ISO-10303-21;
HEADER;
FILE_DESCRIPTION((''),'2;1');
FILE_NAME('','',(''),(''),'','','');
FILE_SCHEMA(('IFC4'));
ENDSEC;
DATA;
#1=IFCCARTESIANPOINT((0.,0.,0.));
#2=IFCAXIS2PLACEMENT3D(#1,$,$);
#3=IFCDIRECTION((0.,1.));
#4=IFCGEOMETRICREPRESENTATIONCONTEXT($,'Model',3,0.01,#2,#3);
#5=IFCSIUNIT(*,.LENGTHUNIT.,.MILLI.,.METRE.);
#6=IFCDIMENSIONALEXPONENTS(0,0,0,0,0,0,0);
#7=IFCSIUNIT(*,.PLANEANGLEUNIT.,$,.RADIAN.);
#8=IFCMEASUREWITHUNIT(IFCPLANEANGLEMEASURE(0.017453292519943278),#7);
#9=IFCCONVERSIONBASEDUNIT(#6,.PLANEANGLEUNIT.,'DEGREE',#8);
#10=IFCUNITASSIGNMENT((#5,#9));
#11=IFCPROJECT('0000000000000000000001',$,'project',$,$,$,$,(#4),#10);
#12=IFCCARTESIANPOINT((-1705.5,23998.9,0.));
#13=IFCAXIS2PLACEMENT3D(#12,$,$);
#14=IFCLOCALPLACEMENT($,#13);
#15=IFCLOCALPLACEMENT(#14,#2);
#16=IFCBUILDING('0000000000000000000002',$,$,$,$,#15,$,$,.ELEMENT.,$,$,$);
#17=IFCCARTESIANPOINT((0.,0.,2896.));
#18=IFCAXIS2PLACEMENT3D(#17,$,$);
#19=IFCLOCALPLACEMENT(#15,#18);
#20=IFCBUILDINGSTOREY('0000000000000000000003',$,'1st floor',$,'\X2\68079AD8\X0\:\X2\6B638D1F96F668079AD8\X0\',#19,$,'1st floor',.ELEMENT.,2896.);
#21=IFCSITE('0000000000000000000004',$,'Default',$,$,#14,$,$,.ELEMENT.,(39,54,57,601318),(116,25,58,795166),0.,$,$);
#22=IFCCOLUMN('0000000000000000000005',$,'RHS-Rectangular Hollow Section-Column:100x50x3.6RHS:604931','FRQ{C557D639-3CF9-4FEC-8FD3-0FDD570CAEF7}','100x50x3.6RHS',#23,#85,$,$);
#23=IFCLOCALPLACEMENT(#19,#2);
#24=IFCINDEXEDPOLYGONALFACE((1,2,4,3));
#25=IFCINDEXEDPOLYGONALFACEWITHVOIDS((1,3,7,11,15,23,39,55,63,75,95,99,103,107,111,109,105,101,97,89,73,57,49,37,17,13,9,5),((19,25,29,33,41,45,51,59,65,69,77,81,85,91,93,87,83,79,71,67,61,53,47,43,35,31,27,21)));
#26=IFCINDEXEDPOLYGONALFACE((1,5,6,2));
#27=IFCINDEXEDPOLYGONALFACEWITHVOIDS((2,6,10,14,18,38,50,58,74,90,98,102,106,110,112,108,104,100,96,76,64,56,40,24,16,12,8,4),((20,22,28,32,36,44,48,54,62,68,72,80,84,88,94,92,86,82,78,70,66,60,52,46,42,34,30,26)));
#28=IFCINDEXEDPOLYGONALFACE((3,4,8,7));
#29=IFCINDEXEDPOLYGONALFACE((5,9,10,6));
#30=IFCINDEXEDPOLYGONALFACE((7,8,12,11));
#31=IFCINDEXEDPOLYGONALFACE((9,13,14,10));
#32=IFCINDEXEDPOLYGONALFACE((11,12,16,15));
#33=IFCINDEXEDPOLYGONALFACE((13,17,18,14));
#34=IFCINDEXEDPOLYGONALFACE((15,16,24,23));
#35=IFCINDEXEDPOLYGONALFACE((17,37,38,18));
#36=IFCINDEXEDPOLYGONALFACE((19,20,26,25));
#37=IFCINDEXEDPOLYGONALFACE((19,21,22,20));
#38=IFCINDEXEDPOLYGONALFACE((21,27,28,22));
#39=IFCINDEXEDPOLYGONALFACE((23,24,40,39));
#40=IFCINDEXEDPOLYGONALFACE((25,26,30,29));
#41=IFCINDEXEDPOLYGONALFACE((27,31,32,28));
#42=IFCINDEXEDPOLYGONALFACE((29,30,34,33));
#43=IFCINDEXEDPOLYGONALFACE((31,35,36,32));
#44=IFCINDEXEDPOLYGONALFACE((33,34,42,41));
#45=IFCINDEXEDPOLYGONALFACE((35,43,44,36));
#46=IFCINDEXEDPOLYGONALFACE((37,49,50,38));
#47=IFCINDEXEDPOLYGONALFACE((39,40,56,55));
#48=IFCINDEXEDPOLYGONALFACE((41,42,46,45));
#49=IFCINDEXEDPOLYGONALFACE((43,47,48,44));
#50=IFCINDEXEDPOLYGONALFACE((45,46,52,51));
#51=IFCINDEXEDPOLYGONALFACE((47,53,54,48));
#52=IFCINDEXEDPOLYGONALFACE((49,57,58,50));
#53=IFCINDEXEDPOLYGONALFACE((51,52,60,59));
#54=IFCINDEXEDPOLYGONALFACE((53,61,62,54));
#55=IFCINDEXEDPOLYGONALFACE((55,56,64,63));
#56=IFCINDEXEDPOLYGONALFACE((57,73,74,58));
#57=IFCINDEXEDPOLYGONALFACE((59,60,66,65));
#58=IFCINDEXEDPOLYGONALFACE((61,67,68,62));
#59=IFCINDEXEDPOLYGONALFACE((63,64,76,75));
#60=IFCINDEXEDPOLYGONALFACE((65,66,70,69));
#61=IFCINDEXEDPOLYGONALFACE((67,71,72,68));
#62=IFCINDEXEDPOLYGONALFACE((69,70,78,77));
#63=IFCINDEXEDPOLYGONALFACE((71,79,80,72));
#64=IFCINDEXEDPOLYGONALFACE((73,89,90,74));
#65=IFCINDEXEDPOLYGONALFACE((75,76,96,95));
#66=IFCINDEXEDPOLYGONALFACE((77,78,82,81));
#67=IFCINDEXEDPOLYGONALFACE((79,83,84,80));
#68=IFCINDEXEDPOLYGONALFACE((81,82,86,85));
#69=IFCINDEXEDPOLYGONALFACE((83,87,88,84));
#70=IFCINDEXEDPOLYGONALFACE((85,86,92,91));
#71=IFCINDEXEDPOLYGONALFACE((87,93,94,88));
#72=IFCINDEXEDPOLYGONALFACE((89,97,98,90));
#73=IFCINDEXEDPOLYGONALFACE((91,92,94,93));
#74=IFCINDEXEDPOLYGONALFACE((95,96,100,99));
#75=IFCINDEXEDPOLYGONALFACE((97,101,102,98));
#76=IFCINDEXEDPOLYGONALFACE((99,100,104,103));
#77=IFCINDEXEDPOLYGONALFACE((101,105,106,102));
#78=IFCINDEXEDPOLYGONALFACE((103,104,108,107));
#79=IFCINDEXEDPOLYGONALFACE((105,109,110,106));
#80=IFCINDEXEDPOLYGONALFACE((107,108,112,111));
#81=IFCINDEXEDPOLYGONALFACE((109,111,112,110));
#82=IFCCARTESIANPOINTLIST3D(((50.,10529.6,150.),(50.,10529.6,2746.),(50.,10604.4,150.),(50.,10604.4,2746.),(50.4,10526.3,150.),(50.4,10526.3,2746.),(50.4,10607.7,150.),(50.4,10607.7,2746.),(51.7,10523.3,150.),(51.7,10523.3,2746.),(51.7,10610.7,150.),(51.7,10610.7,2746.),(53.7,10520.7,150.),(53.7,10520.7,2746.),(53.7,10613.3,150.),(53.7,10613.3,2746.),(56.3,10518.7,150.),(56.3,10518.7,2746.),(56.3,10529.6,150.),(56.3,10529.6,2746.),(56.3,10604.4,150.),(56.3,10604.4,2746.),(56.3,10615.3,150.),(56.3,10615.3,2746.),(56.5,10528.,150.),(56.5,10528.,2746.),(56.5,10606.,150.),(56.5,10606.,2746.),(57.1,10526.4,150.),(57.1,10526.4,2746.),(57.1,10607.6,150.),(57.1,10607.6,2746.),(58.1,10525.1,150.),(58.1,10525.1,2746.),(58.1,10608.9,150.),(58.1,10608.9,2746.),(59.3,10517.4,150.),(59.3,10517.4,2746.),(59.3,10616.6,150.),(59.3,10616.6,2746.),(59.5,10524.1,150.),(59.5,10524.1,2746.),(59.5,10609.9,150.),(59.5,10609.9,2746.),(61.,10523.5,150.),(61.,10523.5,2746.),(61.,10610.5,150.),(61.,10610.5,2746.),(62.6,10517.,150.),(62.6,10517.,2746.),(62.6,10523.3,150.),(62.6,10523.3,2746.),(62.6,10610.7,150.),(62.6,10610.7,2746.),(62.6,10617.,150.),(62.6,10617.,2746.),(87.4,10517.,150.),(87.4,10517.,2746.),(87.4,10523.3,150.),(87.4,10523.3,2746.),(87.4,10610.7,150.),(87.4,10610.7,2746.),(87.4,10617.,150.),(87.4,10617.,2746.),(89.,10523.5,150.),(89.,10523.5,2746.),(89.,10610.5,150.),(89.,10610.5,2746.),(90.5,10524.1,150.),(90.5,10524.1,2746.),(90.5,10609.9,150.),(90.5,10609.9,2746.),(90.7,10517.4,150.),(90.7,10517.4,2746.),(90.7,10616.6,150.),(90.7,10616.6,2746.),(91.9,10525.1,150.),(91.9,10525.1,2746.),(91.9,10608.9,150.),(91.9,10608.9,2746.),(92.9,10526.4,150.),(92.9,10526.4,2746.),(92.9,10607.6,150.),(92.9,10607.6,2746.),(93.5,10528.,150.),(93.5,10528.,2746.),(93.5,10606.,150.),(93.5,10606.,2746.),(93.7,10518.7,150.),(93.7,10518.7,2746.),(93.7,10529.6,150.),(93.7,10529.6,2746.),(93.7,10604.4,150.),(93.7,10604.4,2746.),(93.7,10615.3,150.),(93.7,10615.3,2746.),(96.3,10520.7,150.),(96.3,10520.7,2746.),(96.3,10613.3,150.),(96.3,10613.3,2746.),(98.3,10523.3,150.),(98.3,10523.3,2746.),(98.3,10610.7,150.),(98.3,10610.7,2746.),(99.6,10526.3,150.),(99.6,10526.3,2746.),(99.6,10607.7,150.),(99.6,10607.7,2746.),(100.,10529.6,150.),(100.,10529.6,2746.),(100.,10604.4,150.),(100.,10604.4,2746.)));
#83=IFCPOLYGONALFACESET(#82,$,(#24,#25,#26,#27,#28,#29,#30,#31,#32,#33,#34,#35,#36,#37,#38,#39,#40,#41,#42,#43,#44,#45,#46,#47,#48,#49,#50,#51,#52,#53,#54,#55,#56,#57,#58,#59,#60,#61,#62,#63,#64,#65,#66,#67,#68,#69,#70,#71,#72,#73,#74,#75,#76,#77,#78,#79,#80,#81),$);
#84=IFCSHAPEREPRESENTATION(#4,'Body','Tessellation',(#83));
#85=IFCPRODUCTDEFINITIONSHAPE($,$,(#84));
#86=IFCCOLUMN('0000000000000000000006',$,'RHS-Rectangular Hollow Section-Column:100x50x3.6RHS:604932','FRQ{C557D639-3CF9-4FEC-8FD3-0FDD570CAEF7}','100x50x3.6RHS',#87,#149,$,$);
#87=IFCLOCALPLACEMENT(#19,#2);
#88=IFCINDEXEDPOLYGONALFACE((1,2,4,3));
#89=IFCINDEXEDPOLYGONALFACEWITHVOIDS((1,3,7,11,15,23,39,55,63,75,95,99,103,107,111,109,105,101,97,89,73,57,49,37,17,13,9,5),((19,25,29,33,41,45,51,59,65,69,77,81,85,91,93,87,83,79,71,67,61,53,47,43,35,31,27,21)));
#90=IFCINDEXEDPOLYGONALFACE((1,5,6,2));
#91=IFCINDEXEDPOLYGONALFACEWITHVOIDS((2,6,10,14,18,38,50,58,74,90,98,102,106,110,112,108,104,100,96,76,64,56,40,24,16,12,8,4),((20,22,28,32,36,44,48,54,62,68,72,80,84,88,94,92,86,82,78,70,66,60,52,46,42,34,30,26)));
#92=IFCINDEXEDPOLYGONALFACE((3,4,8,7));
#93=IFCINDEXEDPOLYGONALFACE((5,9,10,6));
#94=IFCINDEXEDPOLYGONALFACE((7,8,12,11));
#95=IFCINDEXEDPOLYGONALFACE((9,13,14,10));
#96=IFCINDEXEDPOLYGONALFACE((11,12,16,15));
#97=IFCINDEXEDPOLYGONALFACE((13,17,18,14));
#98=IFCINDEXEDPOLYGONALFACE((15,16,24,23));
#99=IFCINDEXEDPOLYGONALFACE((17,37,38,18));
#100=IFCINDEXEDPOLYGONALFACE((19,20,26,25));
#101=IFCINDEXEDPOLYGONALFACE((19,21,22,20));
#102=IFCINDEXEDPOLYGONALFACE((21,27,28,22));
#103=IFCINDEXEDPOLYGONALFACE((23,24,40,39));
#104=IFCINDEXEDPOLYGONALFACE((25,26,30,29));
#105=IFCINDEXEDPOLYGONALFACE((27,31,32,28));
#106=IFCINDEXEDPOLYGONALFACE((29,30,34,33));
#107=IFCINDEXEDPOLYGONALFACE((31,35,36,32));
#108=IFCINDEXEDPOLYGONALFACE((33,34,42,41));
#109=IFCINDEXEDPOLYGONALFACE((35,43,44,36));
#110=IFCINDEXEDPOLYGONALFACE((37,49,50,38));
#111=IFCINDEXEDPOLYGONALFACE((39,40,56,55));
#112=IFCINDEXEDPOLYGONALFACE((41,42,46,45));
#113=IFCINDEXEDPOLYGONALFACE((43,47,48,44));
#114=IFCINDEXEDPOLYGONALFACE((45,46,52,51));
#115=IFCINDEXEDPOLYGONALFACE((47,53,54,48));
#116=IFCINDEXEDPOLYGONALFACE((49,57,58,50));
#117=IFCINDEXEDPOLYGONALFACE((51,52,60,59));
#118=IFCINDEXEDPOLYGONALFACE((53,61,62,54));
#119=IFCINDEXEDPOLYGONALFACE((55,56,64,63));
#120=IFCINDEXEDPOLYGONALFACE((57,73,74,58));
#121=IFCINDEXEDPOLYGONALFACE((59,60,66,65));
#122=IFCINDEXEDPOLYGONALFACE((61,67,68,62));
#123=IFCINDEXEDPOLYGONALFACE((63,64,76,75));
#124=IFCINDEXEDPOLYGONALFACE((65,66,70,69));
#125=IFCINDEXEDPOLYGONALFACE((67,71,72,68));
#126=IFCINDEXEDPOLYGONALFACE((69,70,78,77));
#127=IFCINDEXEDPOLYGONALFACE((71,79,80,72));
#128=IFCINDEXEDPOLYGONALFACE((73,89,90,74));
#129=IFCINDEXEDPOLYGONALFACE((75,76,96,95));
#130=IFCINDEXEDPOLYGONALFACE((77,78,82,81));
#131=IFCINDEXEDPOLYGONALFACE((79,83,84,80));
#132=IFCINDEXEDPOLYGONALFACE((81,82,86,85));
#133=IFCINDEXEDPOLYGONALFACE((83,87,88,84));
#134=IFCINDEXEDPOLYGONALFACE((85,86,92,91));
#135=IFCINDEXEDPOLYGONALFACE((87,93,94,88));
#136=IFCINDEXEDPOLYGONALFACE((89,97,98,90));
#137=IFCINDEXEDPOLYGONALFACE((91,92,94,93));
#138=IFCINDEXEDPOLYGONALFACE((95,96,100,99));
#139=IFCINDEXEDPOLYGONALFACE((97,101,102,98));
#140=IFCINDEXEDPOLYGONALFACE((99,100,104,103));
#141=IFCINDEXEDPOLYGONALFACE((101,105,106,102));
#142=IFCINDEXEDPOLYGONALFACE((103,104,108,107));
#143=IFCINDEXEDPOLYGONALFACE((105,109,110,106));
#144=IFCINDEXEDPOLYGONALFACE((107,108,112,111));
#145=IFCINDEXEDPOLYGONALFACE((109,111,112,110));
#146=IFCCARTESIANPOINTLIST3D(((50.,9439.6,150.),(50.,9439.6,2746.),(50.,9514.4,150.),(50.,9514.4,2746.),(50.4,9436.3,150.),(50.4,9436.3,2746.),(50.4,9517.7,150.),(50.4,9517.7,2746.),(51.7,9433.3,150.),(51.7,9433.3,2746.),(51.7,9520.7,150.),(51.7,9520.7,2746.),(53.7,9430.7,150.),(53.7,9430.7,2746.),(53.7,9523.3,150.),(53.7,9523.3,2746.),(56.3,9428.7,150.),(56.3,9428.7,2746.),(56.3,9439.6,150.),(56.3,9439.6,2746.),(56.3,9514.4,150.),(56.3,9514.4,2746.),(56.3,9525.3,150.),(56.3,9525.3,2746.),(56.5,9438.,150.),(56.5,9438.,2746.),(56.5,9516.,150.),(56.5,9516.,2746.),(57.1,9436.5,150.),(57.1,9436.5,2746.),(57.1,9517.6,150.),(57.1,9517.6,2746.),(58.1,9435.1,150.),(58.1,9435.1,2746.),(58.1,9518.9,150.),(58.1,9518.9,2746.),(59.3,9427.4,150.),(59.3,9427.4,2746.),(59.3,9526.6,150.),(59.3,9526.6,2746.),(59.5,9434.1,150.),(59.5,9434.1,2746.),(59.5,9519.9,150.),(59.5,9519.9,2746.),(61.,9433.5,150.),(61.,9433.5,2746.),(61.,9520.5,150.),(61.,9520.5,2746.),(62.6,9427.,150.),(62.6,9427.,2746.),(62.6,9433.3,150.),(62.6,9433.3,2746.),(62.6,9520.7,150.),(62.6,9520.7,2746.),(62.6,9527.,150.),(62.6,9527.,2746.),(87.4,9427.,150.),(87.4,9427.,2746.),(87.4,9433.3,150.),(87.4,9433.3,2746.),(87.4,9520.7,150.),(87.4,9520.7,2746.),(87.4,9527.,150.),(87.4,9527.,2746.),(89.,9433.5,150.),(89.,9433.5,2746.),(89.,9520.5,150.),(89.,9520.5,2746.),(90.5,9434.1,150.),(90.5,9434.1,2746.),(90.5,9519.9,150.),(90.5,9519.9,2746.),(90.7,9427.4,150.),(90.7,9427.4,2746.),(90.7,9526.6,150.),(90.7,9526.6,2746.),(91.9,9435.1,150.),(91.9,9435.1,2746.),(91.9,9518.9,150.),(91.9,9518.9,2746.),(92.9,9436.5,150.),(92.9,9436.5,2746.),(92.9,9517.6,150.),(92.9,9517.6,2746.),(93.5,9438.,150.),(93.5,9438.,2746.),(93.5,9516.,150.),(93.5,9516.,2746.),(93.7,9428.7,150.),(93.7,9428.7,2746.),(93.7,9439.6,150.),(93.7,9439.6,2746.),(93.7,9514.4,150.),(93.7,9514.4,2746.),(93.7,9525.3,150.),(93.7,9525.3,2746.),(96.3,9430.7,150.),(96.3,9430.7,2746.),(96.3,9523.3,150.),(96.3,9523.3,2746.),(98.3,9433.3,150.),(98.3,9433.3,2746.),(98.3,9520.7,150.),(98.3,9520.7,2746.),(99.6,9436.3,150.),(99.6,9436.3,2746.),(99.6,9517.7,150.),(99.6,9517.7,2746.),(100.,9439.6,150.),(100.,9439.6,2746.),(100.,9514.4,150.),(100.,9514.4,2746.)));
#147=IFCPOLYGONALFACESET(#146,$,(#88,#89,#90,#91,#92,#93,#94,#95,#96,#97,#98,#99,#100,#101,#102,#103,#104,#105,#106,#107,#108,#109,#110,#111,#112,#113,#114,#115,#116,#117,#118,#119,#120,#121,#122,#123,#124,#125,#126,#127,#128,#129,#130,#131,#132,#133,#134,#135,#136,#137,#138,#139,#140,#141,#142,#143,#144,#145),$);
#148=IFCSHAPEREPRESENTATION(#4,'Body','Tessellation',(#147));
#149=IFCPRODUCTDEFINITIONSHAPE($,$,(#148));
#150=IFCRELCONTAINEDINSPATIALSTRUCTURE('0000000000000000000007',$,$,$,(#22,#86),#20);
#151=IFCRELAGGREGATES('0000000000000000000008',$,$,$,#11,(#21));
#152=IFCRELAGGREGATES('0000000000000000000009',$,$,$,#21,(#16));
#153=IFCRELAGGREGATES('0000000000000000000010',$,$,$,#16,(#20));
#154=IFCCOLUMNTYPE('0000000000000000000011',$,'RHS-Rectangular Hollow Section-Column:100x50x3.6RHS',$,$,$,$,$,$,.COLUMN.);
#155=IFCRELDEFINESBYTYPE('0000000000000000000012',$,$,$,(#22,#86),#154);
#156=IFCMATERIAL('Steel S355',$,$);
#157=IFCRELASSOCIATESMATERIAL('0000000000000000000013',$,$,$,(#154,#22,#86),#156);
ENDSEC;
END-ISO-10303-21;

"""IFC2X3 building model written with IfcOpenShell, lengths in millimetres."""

from ifc_helpers import new_model, entity, si_unit, converted_unit, direction, frame, origin, origin_2d, place, context, project, spatial, hollow_rectangle, extrude, clip, halfspace, material, type_object, element, save


model = new_model("IFC2X3")

# Units and contexts
model_context = context("Model", 3, precision=0.01, world=origin(), true_north=direction((0.0, 1.0)))
ifc_project = project(units=[si_unit("LENGTHUNIT", "METRE", prefix="MILLI"), converted_unit("PLANEANGLEUNIT", "DEGREE", entity("IfcPlaneAngleMeasure", 0.017453292519943278), si_unit("PLANEANGLEUNIT", "RADIAN"), dimensions=[0, 0, 0, 0, 0, 0, 0])], contexts=[model_context])

# Site, building, storey
site_placement = place(None, frame((-1705.5, 23998.9, 0.0)))
site = spatial("IfcSite", under=ifc_project, at=site_placement, Name="Default", CompositionType="ELEMENT", RefLatitude=(39, 54, 57, 601318), RefLongitude=(116, 25, 58, 795166), RefElevation=0.0)
building_placement = place(site_placement, origin())
building = spatial("IfcBuilding", under=site, at=building_placement, CompositionType="ELEMENT")
storey_placement = place(building_placement, frame((0.0, 0.0, 2896.0)))
storey = spatial("IfcBuildingStorey", under=building, at=storey_placement, Name="1st floor", ObjectType="标高:正负零标高", LongName="1st floor", CompositionType="ELEMENT", Elevation=2896.0)

# Shared definitions
ifc_material_1 = material(Name="Steel S355")

# Columns
column_type_1 = type_object("IfcColumnType", Name="RHS-Rectangular Hollow Section-Column:100x50x3.6RHS", PredefinedType="COLUMN", material=ifc_material_1)
column_1_placement = place(storey_placement, frame((75.0, 10567.0, 2746.0), z_axis=(0.0, 0.0, 1.0), x_axis=(-1.0, 0.0, 0.0)))
element("IfcColumn", 1, at=column_1_placement, inside=storey, type_object=column_type_1, material=ifc_material_1, Name="RHS-Rectangular Hollow Section-Column:100x50x3.6RHS:604931", Description="FRQ{C557D639-3CF9-4FEC-8FD3-0FDD570CAEF7}", ObjectType="100x50x3.6RHS", context=model_context, shape_type="Clipping", body=[
    clip(extrude(hollow_rectangle(XDim=50.0, YDim=100.0, WallThickness=6.3, InnerFilletRadius=6.3, OuterFilletRadius=12.6, at=origin_2d()), origin(), (0.0, 0.0, -1.0), 2651.9), halfspace(frame((75.0, 10567.0, -2596.0), z_axis=(0.0, 0.0, 1.0), x_axis=(-1.0, 0.0, 0.0)), True)),
])
column_2_placement = place(storey_placement, frame((75.0, 9477.0, 2746.0), z_axis=(0.0, 0.0, 1.0), x_axis=(-1.0, 0.0, 0.0)))
element("IfcColumn", 2, at=column_2_placement, inside=storey, type_object=column_type_1, material=ifc_material_1, Name="RHS-Rectangular Hollow Section-Column:100x50x3.6RHS:604932", Description="FRQ{C557D639-3CF9-4FEC-8FD3-0FDD570CAEF7}", ObjectType="100x50x3.6RHS", context=model_context, shape_type="Clipping", body=[
    clip(extrude(hollow_rectangle(XDim=50.0, YDim=100.0, WallThickness=6.3, InnerFilletRadius=6.3, OuterFilletRadius=12.6, at=origin_2d()), origin(), (0.0, 0.0, -1.0), 2651.9), halfspace(frame((75.0, 9477.0, -2596.0), z_axis=(0.0, 0.0, 1.0), x_axis=(-1.0, 0.0, 0.0)), True)),
])

save(model, "model.ifc")
